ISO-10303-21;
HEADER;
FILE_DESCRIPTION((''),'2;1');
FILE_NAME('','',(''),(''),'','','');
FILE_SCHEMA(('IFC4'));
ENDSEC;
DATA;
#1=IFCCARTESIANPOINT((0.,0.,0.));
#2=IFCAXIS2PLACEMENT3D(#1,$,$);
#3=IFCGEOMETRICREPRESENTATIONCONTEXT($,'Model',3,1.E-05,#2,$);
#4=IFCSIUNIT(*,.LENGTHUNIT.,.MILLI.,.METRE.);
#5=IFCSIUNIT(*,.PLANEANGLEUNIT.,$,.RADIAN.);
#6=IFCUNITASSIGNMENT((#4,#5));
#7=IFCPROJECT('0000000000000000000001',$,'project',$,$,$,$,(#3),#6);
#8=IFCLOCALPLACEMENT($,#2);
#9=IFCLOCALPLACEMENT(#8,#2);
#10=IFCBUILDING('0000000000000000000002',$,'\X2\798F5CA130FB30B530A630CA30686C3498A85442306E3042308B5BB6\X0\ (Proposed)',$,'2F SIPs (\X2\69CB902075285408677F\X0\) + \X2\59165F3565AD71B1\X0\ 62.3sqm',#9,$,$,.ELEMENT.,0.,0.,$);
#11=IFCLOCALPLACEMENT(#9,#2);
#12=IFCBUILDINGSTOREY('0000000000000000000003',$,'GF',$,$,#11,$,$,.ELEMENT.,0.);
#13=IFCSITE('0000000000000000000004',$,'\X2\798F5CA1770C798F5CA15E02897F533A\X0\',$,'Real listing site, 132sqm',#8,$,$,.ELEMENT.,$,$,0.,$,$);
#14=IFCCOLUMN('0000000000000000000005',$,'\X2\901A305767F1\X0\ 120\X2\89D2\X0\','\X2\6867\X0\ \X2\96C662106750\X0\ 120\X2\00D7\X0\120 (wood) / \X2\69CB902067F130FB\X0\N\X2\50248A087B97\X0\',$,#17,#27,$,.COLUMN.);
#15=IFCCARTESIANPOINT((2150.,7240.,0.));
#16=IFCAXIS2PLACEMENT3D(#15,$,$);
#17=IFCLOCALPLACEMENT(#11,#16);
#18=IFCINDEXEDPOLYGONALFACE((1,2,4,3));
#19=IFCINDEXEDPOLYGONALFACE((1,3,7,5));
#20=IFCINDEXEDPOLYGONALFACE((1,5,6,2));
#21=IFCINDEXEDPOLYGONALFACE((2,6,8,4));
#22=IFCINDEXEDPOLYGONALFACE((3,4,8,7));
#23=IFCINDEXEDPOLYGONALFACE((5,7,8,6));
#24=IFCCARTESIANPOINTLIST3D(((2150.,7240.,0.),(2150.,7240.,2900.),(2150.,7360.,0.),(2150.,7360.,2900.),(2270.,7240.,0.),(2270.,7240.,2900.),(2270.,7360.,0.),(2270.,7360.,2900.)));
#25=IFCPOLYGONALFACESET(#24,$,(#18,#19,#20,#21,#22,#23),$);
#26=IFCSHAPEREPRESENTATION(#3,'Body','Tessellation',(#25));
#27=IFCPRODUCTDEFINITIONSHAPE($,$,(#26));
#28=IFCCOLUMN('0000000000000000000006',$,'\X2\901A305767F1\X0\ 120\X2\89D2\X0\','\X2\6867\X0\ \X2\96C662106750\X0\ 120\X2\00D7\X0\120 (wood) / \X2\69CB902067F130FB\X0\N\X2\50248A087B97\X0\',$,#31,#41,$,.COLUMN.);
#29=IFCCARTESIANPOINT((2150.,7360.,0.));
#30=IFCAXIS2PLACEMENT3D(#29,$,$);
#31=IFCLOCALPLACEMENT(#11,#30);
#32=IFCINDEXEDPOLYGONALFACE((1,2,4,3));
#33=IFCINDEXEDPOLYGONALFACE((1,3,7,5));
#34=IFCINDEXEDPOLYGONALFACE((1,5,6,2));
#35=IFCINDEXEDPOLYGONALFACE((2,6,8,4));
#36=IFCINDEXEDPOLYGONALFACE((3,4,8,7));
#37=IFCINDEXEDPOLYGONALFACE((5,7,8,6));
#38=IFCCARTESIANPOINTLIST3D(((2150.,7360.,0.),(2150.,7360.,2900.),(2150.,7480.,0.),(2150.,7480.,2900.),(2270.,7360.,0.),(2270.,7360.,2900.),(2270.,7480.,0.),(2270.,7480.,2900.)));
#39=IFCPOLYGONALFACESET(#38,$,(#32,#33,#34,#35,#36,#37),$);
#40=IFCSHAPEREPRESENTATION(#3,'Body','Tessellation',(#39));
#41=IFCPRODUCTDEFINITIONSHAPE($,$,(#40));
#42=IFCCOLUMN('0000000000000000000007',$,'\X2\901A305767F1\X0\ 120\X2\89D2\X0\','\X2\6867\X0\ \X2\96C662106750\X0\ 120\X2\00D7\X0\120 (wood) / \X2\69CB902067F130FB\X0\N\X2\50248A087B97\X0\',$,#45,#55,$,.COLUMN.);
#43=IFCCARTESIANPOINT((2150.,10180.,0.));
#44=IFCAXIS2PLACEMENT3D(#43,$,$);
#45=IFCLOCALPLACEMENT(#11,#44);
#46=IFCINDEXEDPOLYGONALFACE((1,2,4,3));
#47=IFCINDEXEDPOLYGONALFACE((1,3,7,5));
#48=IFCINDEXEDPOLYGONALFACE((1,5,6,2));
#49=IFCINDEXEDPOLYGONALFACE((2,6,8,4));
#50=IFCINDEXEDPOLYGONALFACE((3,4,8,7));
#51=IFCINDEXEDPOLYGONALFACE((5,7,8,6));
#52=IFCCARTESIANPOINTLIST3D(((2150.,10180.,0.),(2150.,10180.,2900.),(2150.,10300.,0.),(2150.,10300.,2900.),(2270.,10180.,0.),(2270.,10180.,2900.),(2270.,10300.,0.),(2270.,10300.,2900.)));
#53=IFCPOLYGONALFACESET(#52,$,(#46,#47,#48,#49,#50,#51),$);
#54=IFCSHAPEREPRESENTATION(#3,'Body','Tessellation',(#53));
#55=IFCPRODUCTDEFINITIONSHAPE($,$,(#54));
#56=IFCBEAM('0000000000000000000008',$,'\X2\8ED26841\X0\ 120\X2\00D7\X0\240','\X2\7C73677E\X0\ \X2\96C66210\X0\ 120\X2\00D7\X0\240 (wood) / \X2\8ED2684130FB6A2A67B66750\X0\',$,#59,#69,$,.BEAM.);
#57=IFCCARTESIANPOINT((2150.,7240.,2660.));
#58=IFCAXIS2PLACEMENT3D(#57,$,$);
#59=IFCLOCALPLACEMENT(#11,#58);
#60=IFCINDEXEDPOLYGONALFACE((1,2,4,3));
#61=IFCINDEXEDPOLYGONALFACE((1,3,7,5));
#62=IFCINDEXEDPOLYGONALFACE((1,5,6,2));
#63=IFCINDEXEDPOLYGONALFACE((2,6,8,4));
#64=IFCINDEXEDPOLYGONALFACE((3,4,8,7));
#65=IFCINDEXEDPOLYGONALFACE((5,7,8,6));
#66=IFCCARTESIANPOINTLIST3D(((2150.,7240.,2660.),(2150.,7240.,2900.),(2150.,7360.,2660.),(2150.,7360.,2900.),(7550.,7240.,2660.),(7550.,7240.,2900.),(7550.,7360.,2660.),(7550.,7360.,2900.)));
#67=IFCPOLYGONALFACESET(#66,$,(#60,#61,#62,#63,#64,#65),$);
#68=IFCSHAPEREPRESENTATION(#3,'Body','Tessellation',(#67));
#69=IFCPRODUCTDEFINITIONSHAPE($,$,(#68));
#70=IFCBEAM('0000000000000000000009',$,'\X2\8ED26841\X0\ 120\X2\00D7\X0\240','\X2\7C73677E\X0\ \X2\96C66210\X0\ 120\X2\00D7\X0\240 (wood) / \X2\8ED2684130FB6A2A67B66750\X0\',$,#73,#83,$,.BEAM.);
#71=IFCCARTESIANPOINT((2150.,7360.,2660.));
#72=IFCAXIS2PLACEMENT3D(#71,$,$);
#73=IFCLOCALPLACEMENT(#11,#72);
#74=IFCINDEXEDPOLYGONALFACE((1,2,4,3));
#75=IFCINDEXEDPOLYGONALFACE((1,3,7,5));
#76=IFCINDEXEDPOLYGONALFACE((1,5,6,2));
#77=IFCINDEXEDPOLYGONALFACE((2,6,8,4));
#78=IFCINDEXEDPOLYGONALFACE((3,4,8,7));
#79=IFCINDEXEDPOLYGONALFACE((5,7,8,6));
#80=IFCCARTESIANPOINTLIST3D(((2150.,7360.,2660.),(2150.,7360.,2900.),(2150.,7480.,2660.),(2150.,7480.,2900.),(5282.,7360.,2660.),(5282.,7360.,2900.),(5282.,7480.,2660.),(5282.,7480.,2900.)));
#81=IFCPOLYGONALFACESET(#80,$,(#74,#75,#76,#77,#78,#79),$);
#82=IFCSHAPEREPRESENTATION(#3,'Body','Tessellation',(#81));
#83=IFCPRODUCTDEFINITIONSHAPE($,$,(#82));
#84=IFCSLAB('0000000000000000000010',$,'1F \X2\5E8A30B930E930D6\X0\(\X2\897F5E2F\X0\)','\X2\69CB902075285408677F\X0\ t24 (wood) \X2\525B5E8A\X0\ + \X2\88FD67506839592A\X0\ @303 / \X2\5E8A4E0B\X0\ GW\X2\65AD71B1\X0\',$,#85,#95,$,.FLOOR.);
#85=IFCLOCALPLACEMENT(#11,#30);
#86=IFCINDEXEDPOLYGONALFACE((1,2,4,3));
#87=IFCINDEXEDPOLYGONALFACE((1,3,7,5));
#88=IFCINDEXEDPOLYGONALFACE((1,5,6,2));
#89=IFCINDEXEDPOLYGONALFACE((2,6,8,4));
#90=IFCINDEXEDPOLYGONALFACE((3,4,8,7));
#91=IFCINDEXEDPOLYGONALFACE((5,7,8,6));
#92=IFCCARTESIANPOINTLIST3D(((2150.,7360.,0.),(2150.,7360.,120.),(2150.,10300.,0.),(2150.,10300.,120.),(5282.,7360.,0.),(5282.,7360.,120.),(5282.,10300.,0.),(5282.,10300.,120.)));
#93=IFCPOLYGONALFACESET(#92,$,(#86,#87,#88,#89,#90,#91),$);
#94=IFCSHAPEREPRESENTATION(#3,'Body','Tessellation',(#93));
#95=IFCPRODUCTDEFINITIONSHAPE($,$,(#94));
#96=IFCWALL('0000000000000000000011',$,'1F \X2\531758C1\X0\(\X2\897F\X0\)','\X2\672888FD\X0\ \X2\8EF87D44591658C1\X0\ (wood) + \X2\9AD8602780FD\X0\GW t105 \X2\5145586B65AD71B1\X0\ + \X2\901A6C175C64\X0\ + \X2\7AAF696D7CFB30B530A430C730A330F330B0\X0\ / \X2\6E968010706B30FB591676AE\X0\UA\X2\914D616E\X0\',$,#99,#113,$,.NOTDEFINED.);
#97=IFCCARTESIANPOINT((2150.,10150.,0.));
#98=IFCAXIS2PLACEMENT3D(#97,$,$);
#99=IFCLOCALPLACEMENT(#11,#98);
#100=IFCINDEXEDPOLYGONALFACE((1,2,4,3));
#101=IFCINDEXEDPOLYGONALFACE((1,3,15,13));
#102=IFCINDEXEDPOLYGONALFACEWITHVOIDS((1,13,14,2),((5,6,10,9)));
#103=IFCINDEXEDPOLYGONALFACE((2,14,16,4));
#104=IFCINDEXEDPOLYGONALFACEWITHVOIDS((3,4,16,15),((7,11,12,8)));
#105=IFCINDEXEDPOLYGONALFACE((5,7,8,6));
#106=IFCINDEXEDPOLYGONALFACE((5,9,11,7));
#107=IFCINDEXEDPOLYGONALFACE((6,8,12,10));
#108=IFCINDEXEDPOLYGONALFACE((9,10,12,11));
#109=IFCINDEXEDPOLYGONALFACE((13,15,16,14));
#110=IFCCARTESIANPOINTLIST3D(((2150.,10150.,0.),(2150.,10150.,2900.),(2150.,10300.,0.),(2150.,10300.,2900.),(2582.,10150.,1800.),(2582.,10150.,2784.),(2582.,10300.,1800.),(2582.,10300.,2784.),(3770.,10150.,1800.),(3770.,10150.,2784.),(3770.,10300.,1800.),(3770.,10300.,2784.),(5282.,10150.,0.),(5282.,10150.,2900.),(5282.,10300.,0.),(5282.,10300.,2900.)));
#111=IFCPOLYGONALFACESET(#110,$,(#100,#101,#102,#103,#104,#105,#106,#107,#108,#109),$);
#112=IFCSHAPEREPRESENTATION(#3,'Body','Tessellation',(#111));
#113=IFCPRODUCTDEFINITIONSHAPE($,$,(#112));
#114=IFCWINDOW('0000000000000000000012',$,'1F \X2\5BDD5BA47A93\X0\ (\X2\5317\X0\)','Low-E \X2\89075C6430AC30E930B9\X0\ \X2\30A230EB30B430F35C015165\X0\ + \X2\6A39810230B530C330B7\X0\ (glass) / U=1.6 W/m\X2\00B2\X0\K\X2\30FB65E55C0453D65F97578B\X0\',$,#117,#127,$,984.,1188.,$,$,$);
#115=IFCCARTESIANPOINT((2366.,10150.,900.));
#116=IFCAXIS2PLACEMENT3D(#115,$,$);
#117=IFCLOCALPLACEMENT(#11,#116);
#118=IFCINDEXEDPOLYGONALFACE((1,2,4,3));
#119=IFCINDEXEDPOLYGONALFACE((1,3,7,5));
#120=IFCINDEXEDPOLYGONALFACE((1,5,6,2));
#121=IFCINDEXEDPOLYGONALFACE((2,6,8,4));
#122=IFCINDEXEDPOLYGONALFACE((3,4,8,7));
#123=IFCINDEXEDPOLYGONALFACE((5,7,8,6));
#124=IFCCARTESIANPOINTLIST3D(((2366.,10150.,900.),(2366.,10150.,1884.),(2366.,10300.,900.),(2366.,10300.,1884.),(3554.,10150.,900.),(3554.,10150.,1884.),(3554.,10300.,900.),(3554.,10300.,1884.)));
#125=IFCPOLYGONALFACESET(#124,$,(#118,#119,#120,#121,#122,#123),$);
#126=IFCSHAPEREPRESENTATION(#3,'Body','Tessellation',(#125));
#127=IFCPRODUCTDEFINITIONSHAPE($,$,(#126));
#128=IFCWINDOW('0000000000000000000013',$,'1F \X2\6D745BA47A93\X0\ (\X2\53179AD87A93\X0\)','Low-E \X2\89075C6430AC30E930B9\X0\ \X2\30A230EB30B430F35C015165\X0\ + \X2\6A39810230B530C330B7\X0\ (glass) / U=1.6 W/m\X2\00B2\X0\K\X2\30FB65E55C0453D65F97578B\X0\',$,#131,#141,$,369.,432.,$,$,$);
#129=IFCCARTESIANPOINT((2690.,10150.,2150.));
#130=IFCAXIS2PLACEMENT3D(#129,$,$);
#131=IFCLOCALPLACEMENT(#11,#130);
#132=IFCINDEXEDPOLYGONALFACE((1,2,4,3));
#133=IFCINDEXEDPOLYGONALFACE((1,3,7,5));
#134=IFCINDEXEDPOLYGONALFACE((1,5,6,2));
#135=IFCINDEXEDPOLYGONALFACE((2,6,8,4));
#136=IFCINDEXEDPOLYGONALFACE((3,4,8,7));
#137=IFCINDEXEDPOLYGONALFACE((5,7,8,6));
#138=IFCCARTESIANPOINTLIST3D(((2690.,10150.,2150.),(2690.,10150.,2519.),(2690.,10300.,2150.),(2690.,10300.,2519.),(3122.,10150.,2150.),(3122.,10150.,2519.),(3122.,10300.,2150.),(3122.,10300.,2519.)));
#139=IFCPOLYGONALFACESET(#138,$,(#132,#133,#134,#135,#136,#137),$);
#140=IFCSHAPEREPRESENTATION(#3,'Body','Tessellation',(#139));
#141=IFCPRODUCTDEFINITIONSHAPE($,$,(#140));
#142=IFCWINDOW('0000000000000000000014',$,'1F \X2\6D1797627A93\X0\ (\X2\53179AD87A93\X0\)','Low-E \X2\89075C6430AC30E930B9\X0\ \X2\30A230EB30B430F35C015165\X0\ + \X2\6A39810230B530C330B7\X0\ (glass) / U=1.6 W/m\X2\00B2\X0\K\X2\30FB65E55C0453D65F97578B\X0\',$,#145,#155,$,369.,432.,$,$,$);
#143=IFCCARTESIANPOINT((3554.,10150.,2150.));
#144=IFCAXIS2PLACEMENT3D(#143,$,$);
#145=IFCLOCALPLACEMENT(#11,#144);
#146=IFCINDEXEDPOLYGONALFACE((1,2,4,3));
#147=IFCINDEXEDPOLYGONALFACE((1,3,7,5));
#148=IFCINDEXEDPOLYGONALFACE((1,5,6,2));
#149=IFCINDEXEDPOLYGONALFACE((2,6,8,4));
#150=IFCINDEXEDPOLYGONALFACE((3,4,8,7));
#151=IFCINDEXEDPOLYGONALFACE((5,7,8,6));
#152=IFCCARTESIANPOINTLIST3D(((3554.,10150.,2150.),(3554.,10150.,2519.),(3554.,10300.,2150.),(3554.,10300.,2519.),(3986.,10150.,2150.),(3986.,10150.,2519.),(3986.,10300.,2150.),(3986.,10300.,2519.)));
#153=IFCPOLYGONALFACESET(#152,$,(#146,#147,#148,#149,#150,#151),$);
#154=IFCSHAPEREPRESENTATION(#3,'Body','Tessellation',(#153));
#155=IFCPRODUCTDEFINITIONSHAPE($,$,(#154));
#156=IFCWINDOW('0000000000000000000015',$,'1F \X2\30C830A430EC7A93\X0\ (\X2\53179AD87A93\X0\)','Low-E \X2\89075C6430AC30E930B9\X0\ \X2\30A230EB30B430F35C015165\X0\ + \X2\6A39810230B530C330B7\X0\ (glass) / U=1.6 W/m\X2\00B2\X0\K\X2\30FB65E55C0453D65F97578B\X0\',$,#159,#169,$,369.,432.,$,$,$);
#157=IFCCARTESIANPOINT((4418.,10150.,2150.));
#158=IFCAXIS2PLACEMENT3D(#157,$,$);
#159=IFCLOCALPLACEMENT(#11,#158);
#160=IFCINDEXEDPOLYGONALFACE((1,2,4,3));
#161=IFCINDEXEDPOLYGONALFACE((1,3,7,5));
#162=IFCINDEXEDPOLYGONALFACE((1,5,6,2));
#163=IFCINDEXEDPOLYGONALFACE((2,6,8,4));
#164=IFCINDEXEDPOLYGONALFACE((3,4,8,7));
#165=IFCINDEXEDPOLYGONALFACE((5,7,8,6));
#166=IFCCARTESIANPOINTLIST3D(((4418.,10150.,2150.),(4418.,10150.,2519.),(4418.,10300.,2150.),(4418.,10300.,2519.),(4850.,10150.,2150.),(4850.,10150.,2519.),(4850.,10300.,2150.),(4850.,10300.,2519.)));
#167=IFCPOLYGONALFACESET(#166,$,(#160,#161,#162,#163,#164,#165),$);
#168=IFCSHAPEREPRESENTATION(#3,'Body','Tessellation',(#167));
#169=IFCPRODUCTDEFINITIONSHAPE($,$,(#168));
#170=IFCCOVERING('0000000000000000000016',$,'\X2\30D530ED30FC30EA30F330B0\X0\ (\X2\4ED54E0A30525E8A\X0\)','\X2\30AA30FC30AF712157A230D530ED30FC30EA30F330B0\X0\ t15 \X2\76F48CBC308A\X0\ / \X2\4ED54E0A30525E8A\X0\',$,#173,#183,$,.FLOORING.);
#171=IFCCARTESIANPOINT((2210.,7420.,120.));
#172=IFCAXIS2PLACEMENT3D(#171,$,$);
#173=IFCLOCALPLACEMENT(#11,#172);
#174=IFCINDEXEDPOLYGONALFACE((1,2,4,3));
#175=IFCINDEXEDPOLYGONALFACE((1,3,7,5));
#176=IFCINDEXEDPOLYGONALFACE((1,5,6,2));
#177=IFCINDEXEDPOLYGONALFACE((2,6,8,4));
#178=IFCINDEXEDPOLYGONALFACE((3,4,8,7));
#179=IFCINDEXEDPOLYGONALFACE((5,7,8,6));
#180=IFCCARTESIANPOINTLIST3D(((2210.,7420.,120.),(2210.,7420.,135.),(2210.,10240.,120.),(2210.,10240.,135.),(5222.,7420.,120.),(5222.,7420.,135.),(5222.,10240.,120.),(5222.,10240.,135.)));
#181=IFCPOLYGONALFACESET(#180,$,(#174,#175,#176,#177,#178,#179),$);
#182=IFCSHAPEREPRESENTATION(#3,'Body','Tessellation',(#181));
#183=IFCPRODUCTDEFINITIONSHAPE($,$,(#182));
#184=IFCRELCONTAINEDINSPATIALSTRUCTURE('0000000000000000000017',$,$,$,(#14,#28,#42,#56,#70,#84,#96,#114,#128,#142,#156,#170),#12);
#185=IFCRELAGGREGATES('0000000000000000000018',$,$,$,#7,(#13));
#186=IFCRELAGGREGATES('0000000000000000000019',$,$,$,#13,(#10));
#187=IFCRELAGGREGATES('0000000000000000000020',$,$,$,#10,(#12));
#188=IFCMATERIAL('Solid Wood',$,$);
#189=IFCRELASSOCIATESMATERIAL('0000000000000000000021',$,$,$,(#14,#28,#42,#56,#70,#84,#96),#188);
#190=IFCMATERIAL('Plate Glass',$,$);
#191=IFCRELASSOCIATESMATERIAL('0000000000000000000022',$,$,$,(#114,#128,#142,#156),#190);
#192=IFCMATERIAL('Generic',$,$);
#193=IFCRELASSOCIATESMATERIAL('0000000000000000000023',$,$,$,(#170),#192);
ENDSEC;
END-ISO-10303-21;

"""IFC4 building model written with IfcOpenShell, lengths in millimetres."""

from ifc_helpers import new_model, si_unit, frame, frame_2d, origin, place, context, project, spatial, rectangle, extrude, material, element, fill, save


model = new_model("IFC4")

# Units and contexts
model_context = context("Model", 3, precision=1e-05, world=origin())
ifc_project = project(units=[si_unit("LENGTHUNIT", "METRE", prefix="MILLI"), si_unit("PLANEANGLEUNIT", "RADIAN")], contexts=[model_context])

# Site, building, storey
site_placement = place(None, origin())
site = spatial("IfcSite", under=ifc_project, at=site_placement, Name="福岡県福岡市西区", ObjectType="Real listing site, 132sqm", CompositionType="ELEMENT", RefElevation=0.0)
building_placement = place(site_placement, origin())
building = spatial("IfcBuilding", under=site, at=building_placement, Name="福岡・サウナと水風呂のある家 (Proposed)", ObjectType="2F SIPs (構造用合板) + 外張断熱 62.3sqm", CompositionType="ELEMENT", ElevationOfRefHeight=0.0, ElevationOfTerrain=0.0)
storey_placement = place(building_placement, origin())
storey = spatial("IfcBuildingStorey", under=building, at=storey_placement, Name="GF", CompositionType="ELEMENT", Elevation=0.0)

# Columns
ifc_material_1 = material(Name="Solid Wood")
column_1_placement = place(storey_placement, frame((2150.0, 7240.0, 0.0)))
element("IfcColumn", 1, at=column_1_placement, inside=storey, material=ifc_material_1, Name="通し柱 120角", Description="桧 集成材 120×120 (wood) / 構造柱・N値計算", PredefinedType="COLUMN", context=model_context, shape_type="SweptSolid", body=[
    extrude(rectangle(XDim=120.0, YDim=120.0, at=frame_2d((60.0, 60.0))), frame((2150.0, 7240.0, 0.0)), (0.0, 0.0, 1.0), 2900.0),
])
column_2_placement = place(storey_placement, frame((2150.0, 7360.0, 0.0)))
element("IfcColumn", 2, at=column_2_placement, inside=storey, material=ifc_material_1, Name="通し柱 120角", Description="桧 集成材 120×120 (wood) / 構造柱・N値計算", PredefinedType="COLUMN", context=model_context, shape_type="SweptSolid", body=[
    extrude(rectangle(XDim=120.0, YDim=120.0, at=frame_2d((60.0, 60.0))), frame((2150.0, 7360.0, 0.0)), (0.0, 0.0, 1.0), 2900.0),
])
column_3_placement = place(storey_placement, frame((2150.0, 10180.0, 0.0)))
element("IfcColumn", 3, at=column_3_placement, inside=storey, material=ifc_material_1, Name="通し柱 120角", Description="桧 集成材 120×120 (wood) / 構造柱・N値計算", PredefinedType="COLUMN", context=model_context, shape_type="SweptSolid", body=[
    extrude(rectangle(XDim=120.0, YDim=120.0, at=frame_2d((60.0, 60.0))), frame((2150.0, 10180.0, 0.0)), (0.0, 0.0, 1.0), 2900.0),
])

# Beams
beam_1_placement = place(storey_placement, frame((2150.0, 7240.0, 2660.0)))
element("IfcBeam", 4, at=beam_1_placement, inside=storey, material=ifc_material_1, Name="軒桁 120×240", Description="米松 集成 120×240 (wood) / 軒桁・横架材", PredefinedType="BEAM", context=model_context, shape_type="SweptSolid", body=[
    extrude(rectangle(XDim=5400.0, YDim=120.0, at=frame_2d((2700.0, 60.0))), frame((2150.0, 7240.0, 2660.0)), (0.0, 0.0, 1.0), 240.0),
])
beam_2_placement = place(storey_placement, frame((2150.0, 7360.0, 2660.0)))
element("IfcBeam", 5, at=beam_2_placement, inside=storey, material=ifc_material_1, Name="軒桁 120×240", Description="米松 集成 120×240 (wood) / 軒桁・横架材", PredefinedType="BEAM", context=model_context, shape_type="SweptSolid", body=[
    extrude(rectangle(XDim=3132.0, YDim=120.0, at=frame_2d((1566.0, 60.0))), frame((2150.0, 7360.0, 2660.0)), (0.0, 0.0, 1.0), 240.0),
])

# Slab
slab_placement = place(storey_placement, frame((2150.0, 7360.0, 0.0)))
element("IfcSlab", 6, at=slab_placement, inside=storey, material=ifc_material_1, Name="1F 床スラブ(西帯)", Description="構造用合板 t24 (wood) 剛床 + 製材根太 @303 / 床下 GW断熱", PredefinedType="FLOOR", context=model_context, shape_type="SweptSolid", body=[
    extrude(rectangle(XDim=3132.0, YDim=2940.0, at=frame_2d((1566.0, 1470.0))), frame((2150.0, 7360.0, 0.0)), (0.0, 0.0, 1.0), 120.0),
])

# Wall, openings, windows
wall_1_placement = place(storey_placement, frame((2150.0, 10150.0, 0.0)))
wall_1 = element("IfcWall", 7, at=wall_1_placement, inside=storey, material=ifc_material_1, Name="1F 北壁(西)", Description="木製 軸組外壁 (wood) + 高性能GW t105 充填断熱 + 通気層 + 窯業系サイディング / 準耐火・外皮UA配慮", PredefinedType="NOTDEFINED", context=model_context, shape_type="SweptSolid", body=[
    extrude(rectangle(XDim=3132.0, YDim=150.0, at=frame_2d((1566.0, 75.0))), frame((2150.0, 10150.0, 0.0)), (0.0, 0.0, 1.0), 2900.0),
])
opening_1_placement = place(storey_placement, frame((2366.0, 10150.0, 900.0)))
opening_1 = element("IfcOpeningElement", 8, at=opening_1_placement, cuts=wall_1, PredefinedType="NOTDEFINED", context=model_context, shape_type="SweptSolid", body=[
    extrude(rectangle(XDim=1188.0, YDim=150.0, at=frame_2d((594.0, 75.0))), frame((2366.0, 10150.0, 900.0)), (0.0, 0.0, 1.0), 984.0),
])
opening_2_placement = place(storey_placement, frame((2690.0, 10150.0, 2150.0)))
opening_2 = element("IfcOpeningElement", 9, at=opening_2_placement, cuts=wall_1, PredefinedType="NOTDEFINED", context=model_context, shape_type="SweptSolid", body=[
    extrude(rectangle(XDim=432.0, YDim=150.0, at=frame_2d((216.0, 75.0))), frame((2690.0, 10150.0, 2150.0)), (0.0, 0.0, 1.0), 369.0),
])
opening_3_placement = place(storey_placement, frame((3554.0, 10150.0, 2150.0)))
opening_3 = element("IfcOpeningElement", 10, at=opening_3_placement, cuts=wall_1, PredefinedType="NOTDEFINED", context=model_context, shape_type="SweptSolid", body=[
    extrude(rectangle(XDim=432.0, YDim=150.0, at=frame_2d((216.0, 75.0))), frame((3554.0, 10150.0, 2150.0)), (0.0, 0.0, 1.0), 369.0),
])
opening_4_placement = place(storey_placement, frame((4418.0, 10150.0, 2150.0)))
opening_4 = element("IfcOpeningElement", 11, at=opening_4_placement, cuts=wall_1, PredefinedType="NOTDEFINED", context=model_context, shape_type="SweptSolid", body=[
    extrude(rectangle(XDim=432.0, YDim=150.0, at=frame_2d((216.0, 75.0))), frame((4418.0, 10150.0, 2150.0)), (0.0, 0.0, 1.0), 369.0),
])
ifc_material_2 = material(Name="Plate Glass")
window_1_placement = place(storey_placement, frame((2366.0, 10150.0, 900.0)))
window_1 = element("IfcWindow", 12, at=window_1_placement, inside=storey, material=ifc_material_2, Name="1F 寝室窓 (北)", Description="Low-E 複層ガラス アルゴン封入 + 樹脂サッシ (glass) / U=1.6 W/m²K・日射取得型", OverallHeight=984.0, OverallWidth=1188.0, context=model_context, shape_type="SweptSolid", body=[
    extrude(rectangle(XDim=1188.0, YDim=150.0, at=frame_2d((594.0, 75.0))), frame((2366.0, 10150.0, 900.0)), (0.0, 0.0, 1.0), 984.0),
])
fill(opening_1, window_1)
window_2_placement = place(storey_placement, frame((2690.0, 10150.0, 2150.0)))
window_2 = element("IfcWindow", 13, at=window_2_placement, inside=storey, material=ifc_material_2, Name="1F 浴室窓 (北高窓)", Description="Low-E 複層ガラス アルゴン封入 + 樹脂サッシ (glass) / U=1.6 W/m²K・日射取得型", OverallHeight=369.0, OverallWidth=432.0, context=model_context, shape_type="SweptSolid", body=[
    extrude(rectangle(XDim=432.0, YDim=150.0, at=frame_2d((216.0, 75.0))), frame((2690.0, 10150.0, 2150.0)), (0.0, 0.0, 1.0), 369.0),
])
fill(opening_2, window_2)
window_3_placement = place(storey_placement, frame((3554.0, 10150.0, 2150.0)))
window_3 = element("IfcWindow", 14, at=window_3_placement, inside=storey, material=ifc_material_2, Name="1F 洗面窓 (北高窓)", Description="Low-E 複層ガラス アルゴン封入 + 樹脂サッシ (glass) / U=1.6 W/m²K・日射取得型", OverallHeight=369.0, OverallWidth=432.0, context=model_context, shape_type="SweptSolid", body=[
    extrude(rectangle(XDim=432.0, YDim=150.0, at=frame_2d((216.0, 75.0))), frame((3554.0, 10150.0, 2150.0)), (0.0, 0.0, 1.0), 369.0),
])
fill(opening_3, window_3)
window_4_placement = place(storey_placement, frame((4418.0, 10150.0, 2150.0)))
window_4 = element("IfcWindow", 15, at=window_4_placement, inside=storey, material=ifc_material_2, Name="1F トイレ窓 (北高窓)", Description="Low-E 複層ガラス アルゴン封入 + 樹脂サッシ (glass) / U=1.6 W/m²K・日射取得型", OverallHeight=369.0, OverallWidth=432.0, context=model_context, shape_type="SweptSolid", body=[
    extrude(rectangle(XDim=432.0, YDim=150.0, at=frame_2d((216.0, 75.0))), frame((4418.0, 10150.0, 2150.0)), (0.0, 0.0, 1.0), 369.0),
])
fill(opening_4, window_4)

# Covering
ifc_material_3 = material(Name="Generic")
covering_placement = place(storey_placement, frame((2210.0, 7420.0, 120.0)))
element("IfcCovering", 16, at=covering_placement, inside=storey, material=ifc_material_3, Name="フローリング (仕上げ床)", Description="オーク無垢フローリング t15 直貼り / 仕上げ床", PredefinedType="FLOORING", context=model_context, shape_type="SweptSolid", body=[
    extrude(rectangle(XDim=3012.0, YDim=2820.0, at=frame_2d((1506.0, 1410.0))), frame((2210.0, 7420.0, 120.0)), (0.0, 0.0, 1.0), 15.0),
])

save(model, "model.ifc")
